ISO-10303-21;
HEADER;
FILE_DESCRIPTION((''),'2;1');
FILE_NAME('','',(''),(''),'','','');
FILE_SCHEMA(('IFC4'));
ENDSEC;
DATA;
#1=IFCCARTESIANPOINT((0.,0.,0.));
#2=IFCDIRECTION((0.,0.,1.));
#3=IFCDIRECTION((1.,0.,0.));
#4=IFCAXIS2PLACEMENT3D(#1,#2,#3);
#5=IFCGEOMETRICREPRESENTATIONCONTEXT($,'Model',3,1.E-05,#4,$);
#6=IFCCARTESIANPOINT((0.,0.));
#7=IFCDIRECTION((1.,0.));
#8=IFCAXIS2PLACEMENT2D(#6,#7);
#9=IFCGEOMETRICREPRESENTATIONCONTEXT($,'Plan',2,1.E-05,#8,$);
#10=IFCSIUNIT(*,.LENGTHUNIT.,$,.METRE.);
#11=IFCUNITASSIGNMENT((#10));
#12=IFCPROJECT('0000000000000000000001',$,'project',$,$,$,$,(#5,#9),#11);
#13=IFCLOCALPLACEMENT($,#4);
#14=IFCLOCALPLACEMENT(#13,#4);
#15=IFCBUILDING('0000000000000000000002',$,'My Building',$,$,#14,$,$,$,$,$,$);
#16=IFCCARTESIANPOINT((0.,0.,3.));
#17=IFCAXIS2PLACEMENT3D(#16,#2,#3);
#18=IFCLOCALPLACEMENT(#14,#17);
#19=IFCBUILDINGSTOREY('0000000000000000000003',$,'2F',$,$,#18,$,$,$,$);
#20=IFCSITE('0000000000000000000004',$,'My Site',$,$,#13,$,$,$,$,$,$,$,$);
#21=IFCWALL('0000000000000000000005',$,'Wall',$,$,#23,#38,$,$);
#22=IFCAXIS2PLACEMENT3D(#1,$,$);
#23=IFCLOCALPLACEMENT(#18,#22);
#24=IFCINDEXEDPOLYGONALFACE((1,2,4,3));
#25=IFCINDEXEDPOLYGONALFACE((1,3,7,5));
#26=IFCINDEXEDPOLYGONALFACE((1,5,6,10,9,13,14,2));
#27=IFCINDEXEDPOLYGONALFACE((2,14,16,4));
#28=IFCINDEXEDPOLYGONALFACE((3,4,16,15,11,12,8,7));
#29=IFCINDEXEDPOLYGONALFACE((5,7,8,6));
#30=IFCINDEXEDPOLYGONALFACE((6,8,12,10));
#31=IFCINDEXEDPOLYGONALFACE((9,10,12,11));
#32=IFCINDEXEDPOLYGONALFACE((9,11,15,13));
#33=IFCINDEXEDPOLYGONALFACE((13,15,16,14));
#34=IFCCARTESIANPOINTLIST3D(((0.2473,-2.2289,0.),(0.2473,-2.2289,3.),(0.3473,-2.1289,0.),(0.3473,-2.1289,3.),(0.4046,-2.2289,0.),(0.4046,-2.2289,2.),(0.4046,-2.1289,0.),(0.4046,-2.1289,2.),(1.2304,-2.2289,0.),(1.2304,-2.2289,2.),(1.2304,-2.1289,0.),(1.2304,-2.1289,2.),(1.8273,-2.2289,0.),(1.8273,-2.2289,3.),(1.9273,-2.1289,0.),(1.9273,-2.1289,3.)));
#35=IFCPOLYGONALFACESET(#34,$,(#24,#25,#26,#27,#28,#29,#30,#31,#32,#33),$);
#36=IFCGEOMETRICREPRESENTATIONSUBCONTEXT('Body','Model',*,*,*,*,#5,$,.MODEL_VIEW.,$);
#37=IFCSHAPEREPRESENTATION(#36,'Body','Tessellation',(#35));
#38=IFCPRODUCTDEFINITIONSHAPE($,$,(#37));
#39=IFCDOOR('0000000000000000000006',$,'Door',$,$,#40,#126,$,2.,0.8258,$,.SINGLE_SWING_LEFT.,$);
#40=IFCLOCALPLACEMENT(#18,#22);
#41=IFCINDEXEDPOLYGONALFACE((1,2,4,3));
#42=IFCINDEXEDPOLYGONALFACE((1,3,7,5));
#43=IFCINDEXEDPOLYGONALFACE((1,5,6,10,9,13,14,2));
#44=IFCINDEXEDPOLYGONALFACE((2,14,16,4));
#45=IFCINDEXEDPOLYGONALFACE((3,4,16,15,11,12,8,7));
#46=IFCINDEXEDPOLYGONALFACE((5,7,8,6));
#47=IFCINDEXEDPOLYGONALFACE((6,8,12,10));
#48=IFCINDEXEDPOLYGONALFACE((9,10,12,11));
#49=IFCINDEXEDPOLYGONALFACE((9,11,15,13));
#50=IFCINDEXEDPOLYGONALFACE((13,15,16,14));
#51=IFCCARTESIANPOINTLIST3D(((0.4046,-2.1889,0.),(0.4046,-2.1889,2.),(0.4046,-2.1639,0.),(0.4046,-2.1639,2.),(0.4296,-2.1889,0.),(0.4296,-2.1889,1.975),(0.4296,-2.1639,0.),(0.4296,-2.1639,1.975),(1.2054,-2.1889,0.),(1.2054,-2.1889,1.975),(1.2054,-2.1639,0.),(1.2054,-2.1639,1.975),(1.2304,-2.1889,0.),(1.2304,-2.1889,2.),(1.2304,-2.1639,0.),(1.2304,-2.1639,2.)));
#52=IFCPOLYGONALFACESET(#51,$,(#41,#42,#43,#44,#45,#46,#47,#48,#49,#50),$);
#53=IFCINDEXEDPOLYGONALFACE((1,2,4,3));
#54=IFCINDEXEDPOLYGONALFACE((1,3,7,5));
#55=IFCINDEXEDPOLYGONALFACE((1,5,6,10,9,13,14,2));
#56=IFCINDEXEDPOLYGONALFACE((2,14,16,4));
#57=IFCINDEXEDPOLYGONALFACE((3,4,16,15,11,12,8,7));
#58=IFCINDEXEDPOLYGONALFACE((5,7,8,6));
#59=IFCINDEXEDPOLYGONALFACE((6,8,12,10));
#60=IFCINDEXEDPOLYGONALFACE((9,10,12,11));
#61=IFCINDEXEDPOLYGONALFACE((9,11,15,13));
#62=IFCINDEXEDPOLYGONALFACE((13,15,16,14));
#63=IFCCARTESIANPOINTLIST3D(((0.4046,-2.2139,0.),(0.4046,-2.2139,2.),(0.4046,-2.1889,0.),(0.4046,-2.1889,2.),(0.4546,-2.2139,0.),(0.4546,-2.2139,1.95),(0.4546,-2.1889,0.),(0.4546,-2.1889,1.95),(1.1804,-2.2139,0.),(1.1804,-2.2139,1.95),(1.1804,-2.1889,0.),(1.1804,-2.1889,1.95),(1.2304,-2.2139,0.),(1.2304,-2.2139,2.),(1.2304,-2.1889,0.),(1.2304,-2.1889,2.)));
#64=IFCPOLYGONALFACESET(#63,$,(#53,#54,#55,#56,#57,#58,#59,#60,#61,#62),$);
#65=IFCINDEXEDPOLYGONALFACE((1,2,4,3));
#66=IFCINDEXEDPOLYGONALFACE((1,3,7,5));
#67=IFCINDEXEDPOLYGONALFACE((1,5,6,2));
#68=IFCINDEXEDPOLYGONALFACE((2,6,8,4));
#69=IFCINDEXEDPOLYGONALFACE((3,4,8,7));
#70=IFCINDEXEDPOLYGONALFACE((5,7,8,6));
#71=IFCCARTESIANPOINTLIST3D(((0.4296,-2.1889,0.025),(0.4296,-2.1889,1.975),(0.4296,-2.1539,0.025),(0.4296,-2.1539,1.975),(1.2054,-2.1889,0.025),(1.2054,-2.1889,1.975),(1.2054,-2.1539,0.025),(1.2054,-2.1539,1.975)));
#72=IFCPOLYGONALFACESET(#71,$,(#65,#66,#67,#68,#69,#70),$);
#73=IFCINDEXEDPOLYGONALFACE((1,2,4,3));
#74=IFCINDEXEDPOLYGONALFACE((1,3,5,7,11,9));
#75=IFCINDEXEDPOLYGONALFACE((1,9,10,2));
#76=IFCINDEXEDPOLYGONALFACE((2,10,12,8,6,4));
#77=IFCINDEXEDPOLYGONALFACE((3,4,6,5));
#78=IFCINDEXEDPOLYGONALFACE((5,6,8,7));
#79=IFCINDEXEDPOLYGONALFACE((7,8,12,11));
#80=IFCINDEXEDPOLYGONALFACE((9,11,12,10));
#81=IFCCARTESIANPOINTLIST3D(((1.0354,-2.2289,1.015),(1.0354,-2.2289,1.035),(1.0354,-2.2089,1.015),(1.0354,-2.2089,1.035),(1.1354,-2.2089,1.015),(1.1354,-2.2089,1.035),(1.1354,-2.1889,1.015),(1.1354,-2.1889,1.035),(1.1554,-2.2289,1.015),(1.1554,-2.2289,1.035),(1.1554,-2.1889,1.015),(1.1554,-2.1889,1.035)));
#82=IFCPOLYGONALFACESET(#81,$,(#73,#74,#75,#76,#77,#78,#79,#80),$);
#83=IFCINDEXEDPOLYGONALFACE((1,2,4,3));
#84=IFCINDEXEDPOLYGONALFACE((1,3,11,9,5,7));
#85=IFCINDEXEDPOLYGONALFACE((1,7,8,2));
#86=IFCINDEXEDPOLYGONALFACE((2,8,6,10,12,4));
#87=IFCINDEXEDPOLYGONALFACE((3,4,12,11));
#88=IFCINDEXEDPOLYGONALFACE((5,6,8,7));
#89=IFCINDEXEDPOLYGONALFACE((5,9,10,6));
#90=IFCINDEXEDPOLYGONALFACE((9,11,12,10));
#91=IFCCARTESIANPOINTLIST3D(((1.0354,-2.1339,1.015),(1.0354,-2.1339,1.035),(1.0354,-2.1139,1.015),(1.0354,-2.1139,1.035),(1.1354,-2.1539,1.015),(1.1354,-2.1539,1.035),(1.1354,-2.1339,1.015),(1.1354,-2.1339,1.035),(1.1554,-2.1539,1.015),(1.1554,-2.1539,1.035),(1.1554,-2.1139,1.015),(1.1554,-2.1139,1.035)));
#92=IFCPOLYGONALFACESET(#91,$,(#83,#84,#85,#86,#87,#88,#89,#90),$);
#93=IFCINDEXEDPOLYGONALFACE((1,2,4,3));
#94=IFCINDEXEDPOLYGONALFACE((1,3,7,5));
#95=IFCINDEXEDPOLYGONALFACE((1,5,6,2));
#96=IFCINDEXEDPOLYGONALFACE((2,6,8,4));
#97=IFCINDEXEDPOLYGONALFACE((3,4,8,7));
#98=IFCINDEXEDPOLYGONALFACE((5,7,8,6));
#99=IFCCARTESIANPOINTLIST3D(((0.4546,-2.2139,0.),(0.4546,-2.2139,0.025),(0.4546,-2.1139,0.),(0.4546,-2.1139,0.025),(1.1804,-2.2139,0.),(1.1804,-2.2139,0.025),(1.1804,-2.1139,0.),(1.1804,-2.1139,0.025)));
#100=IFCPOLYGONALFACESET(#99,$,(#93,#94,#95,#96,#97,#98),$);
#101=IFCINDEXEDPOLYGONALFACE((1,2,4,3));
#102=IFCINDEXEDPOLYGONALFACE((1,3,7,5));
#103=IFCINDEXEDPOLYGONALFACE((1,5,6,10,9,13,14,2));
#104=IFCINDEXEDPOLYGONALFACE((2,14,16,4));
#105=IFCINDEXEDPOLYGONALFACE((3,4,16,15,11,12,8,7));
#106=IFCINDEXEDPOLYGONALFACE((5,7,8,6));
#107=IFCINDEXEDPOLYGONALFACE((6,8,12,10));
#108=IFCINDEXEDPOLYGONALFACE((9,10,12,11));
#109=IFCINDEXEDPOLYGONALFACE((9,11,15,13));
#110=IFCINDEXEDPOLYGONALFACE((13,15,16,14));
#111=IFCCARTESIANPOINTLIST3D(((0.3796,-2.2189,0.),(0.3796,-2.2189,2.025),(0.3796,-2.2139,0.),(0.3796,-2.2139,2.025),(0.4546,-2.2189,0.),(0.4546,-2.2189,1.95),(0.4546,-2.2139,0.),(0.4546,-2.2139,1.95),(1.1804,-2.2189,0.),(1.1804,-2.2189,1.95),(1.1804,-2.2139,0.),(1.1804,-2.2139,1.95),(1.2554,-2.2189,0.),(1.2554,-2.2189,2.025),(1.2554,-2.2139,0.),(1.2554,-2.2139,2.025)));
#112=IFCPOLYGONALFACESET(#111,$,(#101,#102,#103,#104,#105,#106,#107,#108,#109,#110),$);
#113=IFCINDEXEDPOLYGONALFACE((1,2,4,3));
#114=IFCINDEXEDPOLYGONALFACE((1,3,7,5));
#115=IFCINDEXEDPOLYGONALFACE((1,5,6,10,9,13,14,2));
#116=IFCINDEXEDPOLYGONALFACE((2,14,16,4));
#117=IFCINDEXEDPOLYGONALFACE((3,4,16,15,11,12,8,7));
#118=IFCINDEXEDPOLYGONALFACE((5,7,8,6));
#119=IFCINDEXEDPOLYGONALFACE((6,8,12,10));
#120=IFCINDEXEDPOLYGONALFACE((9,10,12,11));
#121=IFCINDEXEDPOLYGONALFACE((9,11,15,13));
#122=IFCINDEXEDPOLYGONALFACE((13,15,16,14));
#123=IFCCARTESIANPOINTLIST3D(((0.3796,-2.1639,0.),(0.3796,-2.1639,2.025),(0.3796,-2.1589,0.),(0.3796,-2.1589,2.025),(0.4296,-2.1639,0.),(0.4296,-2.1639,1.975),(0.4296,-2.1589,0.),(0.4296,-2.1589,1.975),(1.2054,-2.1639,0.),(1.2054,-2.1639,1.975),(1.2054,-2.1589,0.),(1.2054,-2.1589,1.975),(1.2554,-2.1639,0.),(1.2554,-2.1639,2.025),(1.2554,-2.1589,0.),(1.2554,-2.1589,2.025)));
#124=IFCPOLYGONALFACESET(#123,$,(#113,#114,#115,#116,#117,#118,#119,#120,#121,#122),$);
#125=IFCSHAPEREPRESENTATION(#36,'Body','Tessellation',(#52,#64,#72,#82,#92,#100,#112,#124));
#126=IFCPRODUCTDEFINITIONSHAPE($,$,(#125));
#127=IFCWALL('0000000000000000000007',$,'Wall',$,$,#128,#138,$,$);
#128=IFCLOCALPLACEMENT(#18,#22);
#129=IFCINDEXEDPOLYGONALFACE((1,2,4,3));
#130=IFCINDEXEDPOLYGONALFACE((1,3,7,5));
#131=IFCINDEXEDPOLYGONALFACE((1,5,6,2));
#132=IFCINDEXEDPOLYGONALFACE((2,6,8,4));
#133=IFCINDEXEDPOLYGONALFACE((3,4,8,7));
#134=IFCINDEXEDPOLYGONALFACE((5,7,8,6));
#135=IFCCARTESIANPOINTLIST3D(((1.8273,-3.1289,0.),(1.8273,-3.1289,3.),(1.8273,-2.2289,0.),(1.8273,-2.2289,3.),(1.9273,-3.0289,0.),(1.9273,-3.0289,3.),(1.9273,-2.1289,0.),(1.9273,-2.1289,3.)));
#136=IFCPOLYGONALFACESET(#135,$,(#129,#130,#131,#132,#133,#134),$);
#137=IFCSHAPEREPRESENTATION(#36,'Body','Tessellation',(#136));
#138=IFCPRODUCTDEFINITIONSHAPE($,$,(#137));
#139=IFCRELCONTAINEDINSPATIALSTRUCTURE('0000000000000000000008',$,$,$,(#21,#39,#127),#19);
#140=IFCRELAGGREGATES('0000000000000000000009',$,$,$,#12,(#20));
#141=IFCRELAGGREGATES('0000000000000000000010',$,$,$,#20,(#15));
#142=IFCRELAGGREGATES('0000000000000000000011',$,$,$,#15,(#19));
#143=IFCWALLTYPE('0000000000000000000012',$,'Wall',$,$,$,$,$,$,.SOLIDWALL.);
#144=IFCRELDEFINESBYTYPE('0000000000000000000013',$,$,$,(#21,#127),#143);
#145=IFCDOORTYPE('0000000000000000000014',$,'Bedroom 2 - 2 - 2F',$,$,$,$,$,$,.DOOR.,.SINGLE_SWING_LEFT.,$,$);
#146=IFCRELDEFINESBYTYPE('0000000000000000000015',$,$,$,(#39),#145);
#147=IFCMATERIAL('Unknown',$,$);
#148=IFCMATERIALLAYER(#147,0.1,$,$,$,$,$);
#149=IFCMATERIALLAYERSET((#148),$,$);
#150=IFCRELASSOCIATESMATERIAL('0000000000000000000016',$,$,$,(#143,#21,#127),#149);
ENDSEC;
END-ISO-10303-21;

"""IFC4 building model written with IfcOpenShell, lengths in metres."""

from ifc_helpers import new_model, entity, si_unit, frame, origin_with_axes, origin_2d_with_axis, place, context, subcontext, project, spatial, line, indexed_curve, outline, extrude, shape, source, transform, mapped, material, layer, layer_set, layer_usage, type_object, type_shapes, element, fill, save


model = new_model("IFC4")

# Units and contexts
model_context = context("Model", 3, precision=1e-05, world=origin_with_axes())
plan_context = context("Plan", 2, precision=1e-05, world=origin_2d_with_axis())
body_context_1 = subcontext(model_context, "Body", "Model", "MODEL_VIEW")
body_context_2 = subcontext(plan_context, "Body", "Plan", "PLAN_VIEW")
ifc_project = project(units=[si_unit("LENGTHUNIT", "METRE")], contexts=[model_context, plan_context])

# Site, building, storey
site_placement = place(None, origin_with_axes())
site = spatial("IfcSite", under=ifc_project, at=site_placement, Name="My Site")
building_placement = place(site_placement, origin_with_axes())
building = spatial("IfcBuilding", under=site, at=building_placement, Name="My Building")
storey_placement = place(building_placement, frame((0.0, 0.0, 3.0), z_axis=(0.0, 0.0, 1.0), x_axis=(1.0, 0.0, 0.0)))
storey = spatial("IfcBuildingStorey", under=building, at=storey_placement, Name="2F")

# Shared definitions
ifc_material = material(Name="Unknown")

# Shared definitions
ifc_layer_1 = layer(ifc_material, 0.1)
ifc_layer_set_1 = layer_set([ifc_layer_1])
wall_type = type_object("IfcWallType", Name="Wall", PredefinedType="SOLIDWALL", material=ifc_layer_set_1)

# Wall, opening, door
ifc_layer_usage_1 = layer_usage(ifc_layer_set_1, "AXIS2", "POSITIVE", 0.0)
wall_1_placement = place(storey_placement, frame((0.2473, -2.2289, 0.0), z_axis=(0.0, 0.0, 1.0), x_axis=(1.0, 0.0, 0.0)))
wall_1 = element("IfcWall", 1, at=wall_1_placement, inside=storey, type_object=wall_type, material=ifc_layer_usage_1, Name="Wall", context=body_context_1, shape_type="SweptSolid", body=[
    extrude(outline(indexed_curve([(0.0, 0.0), (0.1, 0.1), (1.68, 0.1), (1.58, 0.0)], segments=[line(1, 2, 3, 4, 1)])), origin_with_axes(), (0.0, 0.0, 1.0), 3.0),
])
shared_shape_1 = source(origin_with_axes(), body_context_1, "Body", "SweptSolid", [
    extrude(outline(indexed_curve([(0.0, 0.0), (0.8258, 0.0), (0.8258, 2.0), (0.0, 2.0)], segments=[line(1, 2, 3, 4, 1)])), frame((0.0, -0.6, 0.0), z_axis=(0.0, -1.0, 0.0), x_axis=(1.0, 0.0, 0.0)), (0.0, 0.0, -1.0), 1.2),
])
opening_1_placement = place(wall_1_placement, frame((0.1573, 0.015, 0.0), z_axis=(0.0, 0.0, 1.0), x_axis=(1.0, 0.0, 0.0)))
opening_1 = element("IfcOpeningElement", 2, at=opening_1_placement, cuts=wall_1, PredefinedType="OPENING", context=body_context_1, shape_type="MappedRepresentation", body=[
    mapped(shared_shape_1, transform((0.0, 0.0, 0.0), x_axis=(1.0, 0.0, 0.0), y_axis=(0.0, 1.0, 0.0), z_axis=(0.0, 0.0, 1.0), scale=1.0)),
])
door_type_1 = type_object("IfcDoorType", Name="Bedroom 2 - 2 - 2F", OperationType="SINGLE_SWING_LEFT", PredefinedType="DOOR")
shared_shape_2 = source(origin_with_axes(), body_context_1, "Body", "SweptSolid", [
    extrude(outline(indexed_curve([(0.0, 0.0), (0.0, 2.0), (0.8258, 2.0), (0.8258, 0.0), (0.8008, 0.0), (0.8008, 1.975), (0.025, 1.975), (0.025, 0.0)], segments=[line(1, 2, 3, 4, 5, 6, 7, 8, 1)])), frame((0.0, 0.025, 0.0), z_axis=(0.0, -1.0, 0.0), x_axis=(1.0, 0.0, 0.0)), (0.0, 0.0, -1.0), 0.025),
    extrude(outline(indexed_curve([(0.0, 0.0), (0.0, 2.0), (0.8258, 2.0), (0.8258, 0.0), (0.7758, 0.0), (0.7758, 1.95), (0.05, 1.95), (0.05, 0.0)], segments=[line(1, 2, 3, 4, 5, 6, 7, 8, 1)])), frame((0.0, 0.0, 0.0), z_axis=(0.0, -1.0, 0.0), x_axis=(1.0, 0.0, 0.0)), (0.0, 0.0, -1.0), 0.025),
    extrude(outline(indexed_curve([(0.0, 0.0), (0.7758, 0.0), (0.7758, 0.035), (0.0, 0.035)], segments=[line(1, 2, 3, 4, 1)])), frame((0.025, 0.025, 0.025), z_axis=(0.0, 0.0, 1.0), x_axis=(1.0, 0.0, 0.0)), (0.0, 0.0, 1.0), 1.95),
    extrude(outline(indexed_curve([(0.0, 0.0), (0.0, -0.04), (-0.12, -0.04), (-0.12, -0.02), (-0.02, -0.02), (-0.02, 0.0)], segments=[line(1, 2, 3, 4, 5, 6, 1)])), frame((0.7508, 0.025, 1.015), z_axis=(0.0, 0.0, 1.0), x_axis=(1.0, 0.0, 0.0)), (0.0, 0.0, 1.0), 0.02),
    extrude(outline(indexed_curve([(0.0, 0.0), (0.0, 0.04), (-0.12, 0.04), (-0.12, 0.02), (-0.02, 0.02), (-0.02, 0.0)], segments=[line(1, 2, 3, 4, 5, 6, 1)])), frame((0.7508, 0.06, 1.015), z_axis=(0.0, 0.0, 1.0), x_axis=(1.0, 0.0, 0.0)), (0.0, 0.0, 1.0), 0.02),
    extrude(outline(indexed_curve([(0.0, 0.0), (0.7258, 0.0), (0.7258, 0.1), (0.0, 0.1)], segments=[line(1, 2, 3, 4, 1)])), frame((0.05, 0.0, 0.0), z_axis=(0.0, 0.0, 1.0), x_axis=(1.0, 0.0, 0.0)), (0.0, 0.0, 1.0), 0.025),
    extrude(outline(indexed_curve([(0.0, 0.0), (0.0, 2.025), (0.8758, 2.025), (0.8758, 0.0), (0.8008, 0.0), (0.8008, 1.95), (0.075, 1.95), (0.075, 0.0)], segments=[line(1, 2, 3, 4, 5, 6, 7, 8, 1)])), frame((-0.025, -0.005, 0.0), z_axis=(0.0, -1.0, 0.0), x_axis=(1.0, 0.0, 0.0)), (0.0, 0.0, -1.0), 0.005),
    extrude(outline(indexed_curve([(0.0, 0.0), (0.0, 2.025), (0.8758, 2.025), (0.8758, 0.0), (0.8258, 0.0), (0.8258, 1.975), (0.05, 1.975), (0.05, 0.0)], segments=[line(1, 2, 3, 4, 5, 6, 7, 8, 1)])), frame((-0.025, 0.05, 0.0), z_axis=(0.0, -1.0, 0.0), x_axis=(1.0, 0.0, 0.0)), (0.0, 0.0, -1.0), 0.005),
])
shared_shape_3 = source(origin_with_axes(), body_context_2, "Body", "Curve2D", [
    entity("IfcIndexedPolyCurve", entity("IfcCartesianPointList2D", [[0.0, 0.0], [0.0, 0.05], [0.025, 0.05], [0.025, 0.025], [0.05, 0.025], [0.05, 0.0]]), [entity("IfcLineIndex", [1, 2, 3, 4, 5, 6, 1])]),
    entity("IfcIndexedPolyCurve", entity("IfcCartesianPointList2D", [[0.8258, 0.0], [0.8258, 0.05], [0.8008, 0.05], [0.8008, 0.025], [0.7758, 0.025], [0.7758, 0.0]]), [entity("IfcLineIndex", [1, 2, 3, 4, 5, 6, 1])]),
    entity("IfcTrimmedCurve", entity("IfcEllipse", entity("IfcAxis2Placement2D", entity("IfcCartesianPoint", [0.06, 0.05]), entity("IfcDirection", [1.0, 0.0])), 0.7408, 0.7758), [entity("IfcCartesianPoint", [0.8008, 0.05])], [entity("IfcCartesianPoint", [0.06, 0.8258])], True, "CARTESIAN"),
    entity("IfcIndexedPolyCurve", entity("IfcCartesianPointList2D", [[0.025, 0.05], [0.06, 0.05], [0.06, 0.8258], [0.025, 0.8258]]), [entity("IfcLineIndex", [1, 2, 3, 4, 1])]),
])
type_shapes(door_type_1, [shared_shape_2, shared_shape_3])
door_1_placement = place(opening_1_placement, frame((0.0, 0.0, 0.0), z_axis=(0.0, 0.0, 1.0), x_axis=(1.0, 0.0, 0.0)))
door_1 = element("IfcDoor", 3, at=door_1_placement, inside=storey, type_object=door_type_1, Name="Door", OperationType="SINGLE_SWING_LEFT", OverallHeight=2.0, OverallWidth=0.8258, shapes=[
    shape(body_context_1, "Body", "MappedRepresentation", [mapped(shared_shape_2, transform((0.0, 0.0, 0.0), x_axis=(1.0, 0.0, 0.0), y_axis=(0.0, 1.0, 0.0), z_axis=(0.0, 0.0, 1.0), scale=1.0))]),
    shape(body_context_2, "Body", "MappedRepresentation", [mapped(shared_shape_3, transform((0.0, 0.0, 0.0), x_axis=(1.0, 0.0, 0.0), y_axis=(0.0, 1.0, 0.0), z_axis=(0.0, 0.0, 1.0), scale=1.0))]),
])
fill(opening_1, door_1)

# Wall
ifc_layer_usage_2 = layer_usage(ifc_layer_set_1, "AXIS2", "POSITIVE", 0.0)
wall_2_placement = place(storey_placement, frame((1.8273, -2.2289, 0.0), z_axis=(0.0, 0.0, 1.0), x_axis=(0.0, -1.0, 0.0)))
element("IfcWall", 4, at=wall_2_placement, inside=storey, type_object=wall_type, material=ifc_layer_usage_2, Name="Wall", context=body_context_1, shape_type="SweptSolid", body=[
    extrude(outline(indexed_curve([(0.0, 0.0), (-0.1, 0.1), (0.8, 0.1), (0.9, 0.0)], segments=[line(1, 2, 3, 4, 1)])), origin_with_axes(), (0.0, 0.0, 1.0), 3.0),
])

save(model, "model.ifc")
